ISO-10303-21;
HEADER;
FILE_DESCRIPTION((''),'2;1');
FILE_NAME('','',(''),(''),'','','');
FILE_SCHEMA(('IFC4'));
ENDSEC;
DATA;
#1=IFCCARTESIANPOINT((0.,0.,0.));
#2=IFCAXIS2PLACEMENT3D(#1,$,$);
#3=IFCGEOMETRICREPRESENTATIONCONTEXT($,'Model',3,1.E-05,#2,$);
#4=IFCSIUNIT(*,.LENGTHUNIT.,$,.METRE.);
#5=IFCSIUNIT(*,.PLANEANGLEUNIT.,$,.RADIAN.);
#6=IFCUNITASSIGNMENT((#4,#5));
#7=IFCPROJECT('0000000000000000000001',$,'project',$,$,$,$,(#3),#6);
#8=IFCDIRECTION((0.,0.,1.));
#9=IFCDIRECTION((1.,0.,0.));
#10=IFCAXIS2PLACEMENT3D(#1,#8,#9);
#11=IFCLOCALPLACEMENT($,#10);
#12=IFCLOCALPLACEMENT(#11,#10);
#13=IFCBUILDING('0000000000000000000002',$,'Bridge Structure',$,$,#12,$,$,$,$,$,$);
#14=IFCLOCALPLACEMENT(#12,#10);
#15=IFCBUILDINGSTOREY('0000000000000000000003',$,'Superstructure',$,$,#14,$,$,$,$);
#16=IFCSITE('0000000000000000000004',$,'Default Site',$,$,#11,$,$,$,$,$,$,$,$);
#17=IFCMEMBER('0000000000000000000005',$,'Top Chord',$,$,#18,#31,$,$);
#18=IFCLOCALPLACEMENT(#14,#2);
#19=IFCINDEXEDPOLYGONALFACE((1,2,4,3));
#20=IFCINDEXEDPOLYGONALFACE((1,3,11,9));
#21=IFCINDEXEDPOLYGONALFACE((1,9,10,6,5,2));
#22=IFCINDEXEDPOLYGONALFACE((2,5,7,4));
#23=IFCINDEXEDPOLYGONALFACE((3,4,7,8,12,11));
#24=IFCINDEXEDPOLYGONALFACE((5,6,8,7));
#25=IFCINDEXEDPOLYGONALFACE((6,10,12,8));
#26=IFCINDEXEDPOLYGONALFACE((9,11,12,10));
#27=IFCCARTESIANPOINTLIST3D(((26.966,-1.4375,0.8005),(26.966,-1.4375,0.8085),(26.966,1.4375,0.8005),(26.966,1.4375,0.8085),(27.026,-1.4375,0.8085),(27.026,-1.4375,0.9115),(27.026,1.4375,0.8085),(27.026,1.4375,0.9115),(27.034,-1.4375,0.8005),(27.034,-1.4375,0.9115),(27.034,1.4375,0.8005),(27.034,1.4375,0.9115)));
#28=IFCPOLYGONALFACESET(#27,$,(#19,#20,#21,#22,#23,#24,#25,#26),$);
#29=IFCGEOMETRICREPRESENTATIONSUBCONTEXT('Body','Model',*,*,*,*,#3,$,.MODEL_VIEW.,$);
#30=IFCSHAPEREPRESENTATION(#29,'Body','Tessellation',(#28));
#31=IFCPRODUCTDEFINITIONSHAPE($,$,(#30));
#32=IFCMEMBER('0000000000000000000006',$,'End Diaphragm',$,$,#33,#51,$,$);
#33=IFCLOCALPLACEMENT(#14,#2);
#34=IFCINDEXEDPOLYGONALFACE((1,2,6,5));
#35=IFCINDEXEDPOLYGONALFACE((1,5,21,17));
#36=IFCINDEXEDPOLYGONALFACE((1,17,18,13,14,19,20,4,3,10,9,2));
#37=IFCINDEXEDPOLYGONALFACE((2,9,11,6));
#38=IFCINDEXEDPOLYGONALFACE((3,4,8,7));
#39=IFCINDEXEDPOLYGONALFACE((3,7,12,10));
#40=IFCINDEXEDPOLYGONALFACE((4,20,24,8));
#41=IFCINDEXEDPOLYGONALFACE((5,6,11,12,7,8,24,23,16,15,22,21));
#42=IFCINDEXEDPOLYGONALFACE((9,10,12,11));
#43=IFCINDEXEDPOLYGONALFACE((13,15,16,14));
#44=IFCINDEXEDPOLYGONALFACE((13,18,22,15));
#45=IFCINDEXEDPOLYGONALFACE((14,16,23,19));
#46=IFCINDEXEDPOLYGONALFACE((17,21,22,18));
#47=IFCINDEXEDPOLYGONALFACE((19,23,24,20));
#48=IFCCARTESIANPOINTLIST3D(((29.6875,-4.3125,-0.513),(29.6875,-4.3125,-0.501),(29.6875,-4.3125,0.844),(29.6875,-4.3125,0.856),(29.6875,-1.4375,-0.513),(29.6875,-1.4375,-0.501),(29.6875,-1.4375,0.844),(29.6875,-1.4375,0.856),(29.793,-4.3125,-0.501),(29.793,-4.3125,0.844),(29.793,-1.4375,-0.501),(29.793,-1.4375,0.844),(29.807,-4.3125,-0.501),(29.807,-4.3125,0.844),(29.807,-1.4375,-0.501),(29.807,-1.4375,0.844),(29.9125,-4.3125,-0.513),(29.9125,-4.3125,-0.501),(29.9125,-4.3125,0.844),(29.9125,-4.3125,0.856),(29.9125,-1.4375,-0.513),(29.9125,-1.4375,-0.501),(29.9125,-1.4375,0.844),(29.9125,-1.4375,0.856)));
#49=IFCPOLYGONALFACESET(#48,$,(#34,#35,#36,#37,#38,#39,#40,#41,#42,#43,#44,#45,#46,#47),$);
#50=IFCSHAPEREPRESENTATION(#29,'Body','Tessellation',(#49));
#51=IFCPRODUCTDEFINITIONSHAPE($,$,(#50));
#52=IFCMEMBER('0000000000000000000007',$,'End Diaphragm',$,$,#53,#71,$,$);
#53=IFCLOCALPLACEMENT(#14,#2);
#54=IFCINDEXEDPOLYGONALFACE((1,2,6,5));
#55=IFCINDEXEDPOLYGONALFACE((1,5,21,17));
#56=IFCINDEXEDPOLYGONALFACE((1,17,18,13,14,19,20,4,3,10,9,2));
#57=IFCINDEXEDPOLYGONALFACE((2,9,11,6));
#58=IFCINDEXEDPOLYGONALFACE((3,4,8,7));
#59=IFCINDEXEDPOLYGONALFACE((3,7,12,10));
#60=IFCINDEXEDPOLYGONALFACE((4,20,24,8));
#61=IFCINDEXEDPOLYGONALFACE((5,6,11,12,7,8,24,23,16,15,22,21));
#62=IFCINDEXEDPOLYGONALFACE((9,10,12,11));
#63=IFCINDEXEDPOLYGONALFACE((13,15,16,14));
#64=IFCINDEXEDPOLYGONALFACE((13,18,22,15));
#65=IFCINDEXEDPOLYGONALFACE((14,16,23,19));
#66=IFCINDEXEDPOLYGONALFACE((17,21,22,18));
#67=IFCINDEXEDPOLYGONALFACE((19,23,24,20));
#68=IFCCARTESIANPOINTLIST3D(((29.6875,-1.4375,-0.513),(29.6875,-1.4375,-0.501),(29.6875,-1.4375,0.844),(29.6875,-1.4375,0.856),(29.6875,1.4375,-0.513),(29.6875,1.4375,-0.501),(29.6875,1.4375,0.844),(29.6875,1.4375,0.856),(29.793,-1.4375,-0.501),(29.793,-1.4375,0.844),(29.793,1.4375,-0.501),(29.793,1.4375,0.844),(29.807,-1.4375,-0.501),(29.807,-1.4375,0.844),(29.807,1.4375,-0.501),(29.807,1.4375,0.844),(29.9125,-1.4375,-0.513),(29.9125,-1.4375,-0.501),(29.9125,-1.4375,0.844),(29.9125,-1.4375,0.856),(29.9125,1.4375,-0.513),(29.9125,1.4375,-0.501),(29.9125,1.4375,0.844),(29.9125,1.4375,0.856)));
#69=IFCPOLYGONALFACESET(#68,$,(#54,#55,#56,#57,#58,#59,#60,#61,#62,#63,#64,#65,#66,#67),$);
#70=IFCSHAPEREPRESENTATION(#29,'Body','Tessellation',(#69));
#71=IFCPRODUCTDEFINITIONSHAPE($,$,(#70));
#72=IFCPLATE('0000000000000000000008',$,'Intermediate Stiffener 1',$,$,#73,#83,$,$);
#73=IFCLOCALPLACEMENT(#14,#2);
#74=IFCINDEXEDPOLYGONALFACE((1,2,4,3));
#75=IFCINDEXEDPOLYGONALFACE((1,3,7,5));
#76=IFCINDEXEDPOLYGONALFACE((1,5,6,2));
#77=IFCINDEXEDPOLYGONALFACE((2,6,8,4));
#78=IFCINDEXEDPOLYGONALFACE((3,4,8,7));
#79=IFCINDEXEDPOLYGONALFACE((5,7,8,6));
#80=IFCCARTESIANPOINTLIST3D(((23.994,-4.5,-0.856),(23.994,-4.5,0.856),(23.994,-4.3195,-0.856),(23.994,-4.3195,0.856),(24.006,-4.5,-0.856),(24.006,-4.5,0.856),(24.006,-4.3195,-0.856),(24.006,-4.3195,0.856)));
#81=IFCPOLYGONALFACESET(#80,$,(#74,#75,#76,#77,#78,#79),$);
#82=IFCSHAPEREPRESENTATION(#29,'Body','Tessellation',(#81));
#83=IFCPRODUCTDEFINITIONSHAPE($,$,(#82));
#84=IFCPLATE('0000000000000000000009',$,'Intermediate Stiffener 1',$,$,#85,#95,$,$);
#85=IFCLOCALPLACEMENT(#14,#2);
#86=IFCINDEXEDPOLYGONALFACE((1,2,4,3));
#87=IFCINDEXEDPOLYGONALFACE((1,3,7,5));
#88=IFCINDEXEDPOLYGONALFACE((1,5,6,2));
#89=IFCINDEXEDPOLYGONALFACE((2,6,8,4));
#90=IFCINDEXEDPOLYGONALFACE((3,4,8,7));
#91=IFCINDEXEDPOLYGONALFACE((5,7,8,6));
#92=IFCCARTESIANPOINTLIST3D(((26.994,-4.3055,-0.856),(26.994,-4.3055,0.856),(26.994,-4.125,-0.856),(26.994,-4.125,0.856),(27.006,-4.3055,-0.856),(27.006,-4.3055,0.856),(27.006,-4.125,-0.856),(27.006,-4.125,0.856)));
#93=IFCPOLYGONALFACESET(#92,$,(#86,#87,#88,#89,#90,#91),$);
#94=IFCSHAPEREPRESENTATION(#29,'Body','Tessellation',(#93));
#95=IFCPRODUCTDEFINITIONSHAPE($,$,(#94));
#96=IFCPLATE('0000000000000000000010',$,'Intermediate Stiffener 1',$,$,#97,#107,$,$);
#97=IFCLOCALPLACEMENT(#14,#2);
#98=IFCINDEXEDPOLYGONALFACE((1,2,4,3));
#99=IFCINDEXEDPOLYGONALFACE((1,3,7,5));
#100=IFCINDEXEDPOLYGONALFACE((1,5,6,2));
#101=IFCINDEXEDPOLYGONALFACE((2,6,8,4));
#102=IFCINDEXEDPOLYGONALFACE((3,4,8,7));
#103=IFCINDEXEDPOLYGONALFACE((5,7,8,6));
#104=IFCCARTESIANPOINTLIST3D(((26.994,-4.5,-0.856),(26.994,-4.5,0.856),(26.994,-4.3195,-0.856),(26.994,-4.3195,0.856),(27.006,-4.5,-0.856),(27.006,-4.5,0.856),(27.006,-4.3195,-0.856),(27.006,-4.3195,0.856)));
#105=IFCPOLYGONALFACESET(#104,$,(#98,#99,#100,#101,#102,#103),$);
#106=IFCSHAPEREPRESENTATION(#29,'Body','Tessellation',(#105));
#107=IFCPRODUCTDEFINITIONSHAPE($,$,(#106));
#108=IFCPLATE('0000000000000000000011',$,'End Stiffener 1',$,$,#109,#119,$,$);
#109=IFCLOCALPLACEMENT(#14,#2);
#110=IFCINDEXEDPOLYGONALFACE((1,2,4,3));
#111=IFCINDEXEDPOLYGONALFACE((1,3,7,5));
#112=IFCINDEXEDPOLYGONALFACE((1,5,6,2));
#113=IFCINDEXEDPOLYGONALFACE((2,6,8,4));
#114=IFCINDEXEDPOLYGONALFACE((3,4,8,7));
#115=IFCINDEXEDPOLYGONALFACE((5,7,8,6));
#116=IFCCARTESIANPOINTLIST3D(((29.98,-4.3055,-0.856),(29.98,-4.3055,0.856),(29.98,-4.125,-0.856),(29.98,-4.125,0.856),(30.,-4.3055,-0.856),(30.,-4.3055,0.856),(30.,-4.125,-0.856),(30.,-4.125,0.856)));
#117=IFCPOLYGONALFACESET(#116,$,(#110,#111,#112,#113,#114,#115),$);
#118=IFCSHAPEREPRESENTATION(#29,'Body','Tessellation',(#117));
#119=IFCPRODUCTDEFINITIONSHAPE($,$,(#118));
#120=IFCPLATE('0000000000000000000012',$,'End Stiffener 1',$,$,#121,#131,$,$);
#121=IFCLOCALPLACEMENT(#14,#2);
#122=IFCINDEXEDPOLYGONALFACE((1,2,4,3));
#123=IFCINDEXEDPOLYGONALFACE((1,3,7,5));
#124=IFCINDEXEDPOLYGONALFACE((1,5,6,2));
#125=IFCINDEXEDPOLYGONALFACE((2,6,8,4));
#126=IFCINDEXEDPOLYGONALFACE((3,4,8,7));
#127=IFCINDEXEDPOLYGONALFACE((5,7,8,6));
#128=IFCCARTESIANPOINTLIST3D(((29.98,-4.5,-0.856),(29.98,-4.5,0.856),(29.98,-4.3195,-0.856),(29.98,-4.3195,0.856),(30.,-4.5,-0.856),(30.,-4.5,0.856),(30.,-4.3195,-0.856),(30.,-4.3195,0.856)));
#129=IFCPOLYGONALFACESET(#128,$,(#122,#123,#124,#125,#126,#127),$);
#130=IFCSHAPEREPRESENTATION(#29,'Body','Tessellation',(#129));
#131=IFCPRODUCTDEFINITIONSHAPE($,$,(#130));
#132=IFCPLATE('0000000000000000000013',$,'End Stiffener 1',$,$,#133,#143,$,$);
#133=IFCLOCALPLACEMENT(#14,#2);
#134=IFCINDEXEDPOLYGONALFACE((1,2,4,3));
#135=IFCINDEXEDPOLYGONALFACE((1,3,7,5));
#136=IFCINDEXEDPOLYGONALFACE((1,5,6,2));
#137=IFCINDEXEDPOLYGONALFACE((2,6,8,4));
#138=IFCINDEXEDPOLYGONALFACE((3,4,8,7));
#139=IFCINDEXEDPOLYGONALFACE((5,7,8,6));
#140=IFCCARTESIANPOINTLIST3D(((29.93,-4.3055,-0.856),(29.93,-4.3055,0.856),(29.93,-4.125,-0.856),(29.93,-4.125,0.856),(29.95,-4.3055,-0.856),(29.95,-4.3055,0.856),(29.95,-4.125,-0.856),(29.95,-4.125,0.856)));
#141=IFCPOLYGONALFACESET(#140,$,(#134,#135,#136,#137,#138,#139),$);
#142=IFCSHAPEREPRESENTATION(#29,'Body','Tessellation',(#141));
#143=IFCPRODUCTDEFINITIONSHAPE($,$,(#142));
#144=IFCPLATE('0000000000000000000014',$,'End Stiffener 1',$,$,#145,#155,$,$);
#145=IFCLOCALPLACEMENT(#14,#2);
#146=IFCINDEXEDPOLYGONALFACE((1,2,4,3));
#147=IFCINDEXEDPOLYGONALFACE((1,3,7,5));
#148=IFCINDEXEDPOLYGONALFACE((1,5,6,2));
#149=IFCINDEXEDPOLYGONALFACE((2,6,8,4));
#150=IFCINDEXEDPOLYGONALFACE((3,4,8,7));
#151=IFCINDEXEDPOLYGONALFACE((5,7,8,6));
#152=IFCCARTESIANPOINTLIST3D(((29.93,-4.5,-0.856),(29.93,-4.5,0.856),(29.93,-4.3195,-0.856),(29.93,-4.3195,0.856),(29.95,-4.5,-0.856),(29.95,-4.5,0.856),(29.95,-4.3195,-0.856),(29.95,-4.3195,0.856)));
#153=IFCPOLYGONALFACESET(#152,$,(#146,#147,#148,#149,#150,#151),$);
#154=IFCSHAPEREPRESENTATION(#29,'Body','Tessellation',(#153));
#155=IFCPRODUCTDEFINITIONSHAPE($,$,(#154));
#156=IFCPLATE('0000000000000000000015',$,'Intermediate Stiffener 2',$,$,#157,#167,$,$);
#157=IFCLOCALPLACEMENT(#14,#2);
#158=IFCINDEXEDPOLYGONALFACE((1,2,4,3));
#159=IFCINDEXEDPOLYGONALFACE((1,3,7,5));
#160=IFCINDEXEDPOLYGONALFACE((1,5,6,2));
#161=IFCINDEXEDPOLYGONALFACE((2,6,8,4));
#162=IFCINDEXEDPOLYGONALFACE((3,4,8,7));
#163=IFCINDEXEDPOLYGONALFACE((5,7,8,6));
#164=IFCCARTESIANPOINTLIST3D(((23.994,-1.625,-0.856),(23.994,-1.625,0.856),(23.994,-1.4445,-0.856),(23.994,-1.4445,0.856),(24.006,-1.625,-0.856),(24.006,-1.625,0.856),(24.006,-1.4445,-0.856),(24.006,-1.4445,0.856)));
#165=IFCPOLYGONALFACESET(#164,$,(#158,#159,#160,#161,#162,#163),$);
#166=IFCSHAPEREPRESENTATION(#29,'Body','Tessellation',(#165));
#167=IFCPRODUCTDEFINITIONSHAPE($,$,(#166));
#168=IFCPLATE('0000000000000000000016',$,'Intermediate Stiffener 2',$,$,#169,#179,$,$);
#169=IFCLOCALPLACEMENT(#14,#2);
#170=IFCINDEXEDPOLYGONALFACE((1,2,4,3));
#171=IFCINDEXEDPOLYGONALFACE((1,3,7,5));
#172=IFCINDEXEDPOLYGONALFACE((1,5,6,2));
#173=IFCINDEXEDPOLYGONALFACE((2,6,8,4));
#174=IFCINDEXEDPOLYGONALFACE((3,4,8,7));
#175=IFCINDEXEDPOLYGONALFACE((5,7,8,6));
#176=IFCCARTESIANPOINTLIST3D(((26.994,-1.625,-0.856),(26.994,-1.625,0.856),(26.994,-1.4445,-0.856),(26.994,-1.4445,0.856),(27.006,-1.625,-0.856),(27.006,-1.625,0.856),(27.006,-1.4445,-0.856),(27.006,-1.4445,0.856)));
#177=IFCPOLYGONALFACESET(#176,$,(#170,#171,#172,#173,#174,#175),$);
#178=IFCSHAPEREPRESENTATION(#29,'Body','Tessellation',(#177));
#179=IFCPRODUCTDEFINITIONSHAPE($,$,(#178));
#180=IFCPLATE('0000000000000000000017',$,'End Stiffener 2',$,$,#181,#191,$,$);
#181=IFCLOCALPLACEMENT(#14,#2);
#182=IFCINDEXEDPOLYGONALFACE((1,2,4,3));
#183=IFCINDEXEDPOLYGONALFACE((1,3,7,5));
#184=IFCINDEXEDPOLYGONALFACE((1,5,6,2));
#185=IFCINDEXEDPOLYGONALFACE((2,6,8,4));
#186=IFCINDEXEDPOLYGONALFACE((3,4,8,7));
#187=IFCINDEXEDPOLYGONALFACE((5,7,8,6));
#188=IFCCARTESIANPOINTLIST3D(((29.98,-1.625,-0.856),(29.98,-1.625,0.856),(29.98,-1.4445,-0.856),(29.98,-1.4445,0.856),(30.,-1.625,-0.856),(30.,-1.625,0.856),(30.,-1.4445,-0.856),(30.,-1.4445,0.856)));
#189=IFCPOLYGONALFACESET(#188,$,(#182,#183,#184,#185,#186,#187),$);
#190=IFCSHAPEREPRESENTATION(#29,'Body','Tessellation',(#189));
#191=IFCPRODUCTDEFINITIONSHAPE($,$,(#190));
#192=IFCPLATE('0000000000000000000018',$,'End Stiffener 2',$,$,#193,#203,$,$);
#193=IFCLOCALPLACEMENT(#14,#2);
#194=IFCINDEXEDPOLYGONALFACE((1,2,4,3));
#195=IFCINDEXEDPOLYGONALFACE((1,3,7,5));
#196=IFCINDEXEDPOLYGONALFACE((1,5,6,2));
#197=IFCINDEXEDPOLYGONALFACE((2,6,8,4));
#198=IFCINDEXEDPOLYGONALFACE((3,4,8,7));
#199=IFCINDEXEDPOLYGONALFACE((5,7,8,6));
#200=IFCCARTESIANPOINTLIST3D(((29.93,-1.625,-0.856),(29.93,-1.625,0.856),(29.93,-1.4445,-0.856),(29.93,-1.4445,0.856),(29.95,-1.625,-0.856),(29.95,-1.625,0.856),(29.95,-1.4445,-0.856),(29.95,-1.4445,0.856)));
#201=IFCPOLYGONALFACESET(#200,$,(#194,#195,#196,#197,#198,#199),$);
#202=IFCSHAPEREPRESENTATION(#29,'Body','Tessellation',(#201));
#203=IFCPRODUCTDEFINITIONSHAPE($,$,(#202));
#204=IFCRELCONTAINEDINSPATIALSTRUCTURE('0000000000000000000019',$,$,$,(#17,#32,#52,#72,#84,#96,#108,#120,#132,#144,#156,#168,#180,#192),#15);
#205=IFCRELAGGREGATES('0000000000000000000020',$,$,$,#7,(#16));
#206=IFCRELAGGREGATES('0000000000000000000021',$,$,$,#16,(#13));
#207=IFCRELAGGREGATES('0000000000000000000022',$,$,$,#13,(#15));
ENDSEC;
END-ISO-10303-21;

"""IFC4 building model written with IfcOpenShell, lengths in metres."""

from ifc_helpers import new_model, si_unit, frame, origin, origin_with_axes, origin_2d_with_axis, place, context, subcontext, project, spatial, rectangle, i_section, l_section, extrude, element, save


model = new_model("IFC4")

# Units and contexts
model_context = context("Model", 3, precision=1e-05, world=origin())
body_context = subcontext(model_context, "Body", "Model", "MODEL_VIEW")
ifc_project = project(units=[si_unit("LENGTHUNIT", "METRE"), si_unit("PLANEANGLEUNIT", "RADIAN")], contexts=[model_context])

# Site, building, storey
site_placement = place(None, origin_with_axes())
site = spatial("IfcSite", under=ifc_project, at=site_placement, Name="Default Site")
building_placement = place(site_placement, origin_with_axes())
building = spatial("IfcBuilding", under=site, at=building_placement, Name="Bridge Structure")
storey_placement = place(building_placement, origin_with_axes())
storey = spatial("IfcBuildingStorey", under=building, at=storey_placement, Name="Superstructure")

# Members
for number, where, z_axis, x_axis, name in (
    (1, (27.0, -1.4375, 0.856), (0.0, 1.0, 0.0), (-1.0, 0.0, 0.0), "Top Chord"),
):
    element("IfcMember", number, at=place(storey_placement, frame(where, z_axis=z_axis, x_axis=x_axis)), inside=storey, Name=name, context=body_context, shape_type="SweptSolid", body=[
        extrude(l_section(Depth=0.111, Width=0.068, Thickness=0.008, at=origin_2d_with_axis()), origin_with_axes(), (0.0, 0.0, 1.0), 2.875),
    ])
for number, where, z_axis, x_axis, name in (
    (2, (29.8, -4.3125, 0.1715), (0.0, 1.0, 0.0), (-1.0, 0.0, 0.0), "End Diaphragm"),
    (3, (29.8, -1.4375, 0.1715), (0.0, 1.0, 0.0), (-1.0, 0.0, 0.0), "End Diaphragm"),
):
    element("IfcMember", number, at=place(storey_placement, frame(where, z_axis=z_axis, x_axis=x_axis)), inside=storey, Name=name, context=body_context, shape_type="SweptSolid", body=[
        extrude(i_section(OverallWidth=0.225, OverallDepth=1.369, WebThickness=0.014, FlangeThickness=0.012, at=origin_2d_with_axis()), origin_with_axes(), (0.0, 0.0, 1.0), 2.875),
    ])

# Plates
for number, where, z_axis, x_axis, name in (
    (4, (24.0, -4.4097, -0.856), (0.0, 0.0, 1.0), (1.0, 0.0, 0.0), "Intermediate Stiffener 1"),
    (5, (27.0, -4.2153, -0.856), (0.0, 0.0, 1.0), (1.0, 0.0, 0.0), "Intermediate Stiffener 1"),
    (6, (27.0, -4.4097, -0.856), (0.0, 0.0, 1.0), (1.0, 0.0, 0.0), "Intermediate Stiffener 1"),
):
    element("IfcPlate", number, at=place(storey_placement, frame(where, z_axis=z_axis, x_axis=x_axis)), inside=storey, Name=name, context=body_context, shape_type="SweptSolid", body=[
        extrude(rectangle(XDim=0.012, YDim=0.1805, at=origin_2d_with_axis()), origin_with_axes(), (0.0, 0.0, 1.0), 1.712),
    ])
for number, where, z_axis, x_axis, name in (
    (7, (29.99, -4.2153, -0.856), (0.0, 0.0, 1.0), (1.0, 0.0, 0.0), "End Stiffener 1"),
    (8, (29.99, -4.4097, -0.856), (0.0, 0.0, 1.0), (1.0, 0.0, 0.0), "End Stiffener 1"),
    (9, (29.94, -4.2153, -0.856), (0.0, 0.0, 1.0), (1.0, 0.0, 0.0), "End Stiffener 1"),
    (10, (29.94, -4.4097, -0.856), (0.0, 0.0, 1.0), (1.0, 0.0, 0.0), "End Stiffener 1"),
):
    element("IfcPlate", number, at=place(storey_placement, frame(where, z_axis=z_axis, x_axis=x_axis)), inside=storey, Name=name, context=body_context, shape_type="SweptSolid", body=[
        extrude(rectangle(XDim=0.02, YDim=0.1805, at=origin_2d_with_axis()), origin_with_axes(), (0.0, 0.0, 1.0), 1.712),
    ])
for number, where, z_axis, x_axis, name in (
    (11, (24.0, -1.5348, -0.856), (0.0, 0.0, 1.0), (1.0, 0.0, 0.0), "Intermediate Stiffener 2"),
    (12, (27.0, -1.5348, -0.856), (0.0, 0.0, 1.0), (1.0, 0.0, 0.0), "Intermediate Stiffener 2"),
):
    element("IfcPlate", number, at=place(storey_placement, frame(where, z_axis=z_axis, x_axis=x_axis)), inside=storey, Name=name, context=body_context, shape_type="SweptSolid", body=[
        extrude(rectangle(XDim=0.012, YDim=0.1805, at=origin_2d_with_axis()), origin_with_axes(), (0.0, 0.0, 1.0), 1.712),
    ])
for number, where, z_axis, x_axis, name in (
    (13, (29.99, -1.5348, -0.856), (0.0, 0.0, 1.0), (1.0, 0.0, 0.0), "End Stiffener 2"),
    (14, (29.94, -1.5348, -0.856), (0.0, 0.0, 1.0), (1.0, 0.0, 0.0), "End Stiffener 2"),
):
    element("IfcPlate", number, at=place(storey_placement, frame(where, z_axis=z_axis, x_axis=x_axis)), inside=storey, Name=name, context=body_context, shape_type="SweptSolid", body=[
        extrude(rectangle(XDim=0.02, YDim=0.1805, at=origin_2d_with_axis()), origin_with_axes(), (0.0, 0.0, 1.0), 1.712),
    ])

save(model, "model.ifc")
